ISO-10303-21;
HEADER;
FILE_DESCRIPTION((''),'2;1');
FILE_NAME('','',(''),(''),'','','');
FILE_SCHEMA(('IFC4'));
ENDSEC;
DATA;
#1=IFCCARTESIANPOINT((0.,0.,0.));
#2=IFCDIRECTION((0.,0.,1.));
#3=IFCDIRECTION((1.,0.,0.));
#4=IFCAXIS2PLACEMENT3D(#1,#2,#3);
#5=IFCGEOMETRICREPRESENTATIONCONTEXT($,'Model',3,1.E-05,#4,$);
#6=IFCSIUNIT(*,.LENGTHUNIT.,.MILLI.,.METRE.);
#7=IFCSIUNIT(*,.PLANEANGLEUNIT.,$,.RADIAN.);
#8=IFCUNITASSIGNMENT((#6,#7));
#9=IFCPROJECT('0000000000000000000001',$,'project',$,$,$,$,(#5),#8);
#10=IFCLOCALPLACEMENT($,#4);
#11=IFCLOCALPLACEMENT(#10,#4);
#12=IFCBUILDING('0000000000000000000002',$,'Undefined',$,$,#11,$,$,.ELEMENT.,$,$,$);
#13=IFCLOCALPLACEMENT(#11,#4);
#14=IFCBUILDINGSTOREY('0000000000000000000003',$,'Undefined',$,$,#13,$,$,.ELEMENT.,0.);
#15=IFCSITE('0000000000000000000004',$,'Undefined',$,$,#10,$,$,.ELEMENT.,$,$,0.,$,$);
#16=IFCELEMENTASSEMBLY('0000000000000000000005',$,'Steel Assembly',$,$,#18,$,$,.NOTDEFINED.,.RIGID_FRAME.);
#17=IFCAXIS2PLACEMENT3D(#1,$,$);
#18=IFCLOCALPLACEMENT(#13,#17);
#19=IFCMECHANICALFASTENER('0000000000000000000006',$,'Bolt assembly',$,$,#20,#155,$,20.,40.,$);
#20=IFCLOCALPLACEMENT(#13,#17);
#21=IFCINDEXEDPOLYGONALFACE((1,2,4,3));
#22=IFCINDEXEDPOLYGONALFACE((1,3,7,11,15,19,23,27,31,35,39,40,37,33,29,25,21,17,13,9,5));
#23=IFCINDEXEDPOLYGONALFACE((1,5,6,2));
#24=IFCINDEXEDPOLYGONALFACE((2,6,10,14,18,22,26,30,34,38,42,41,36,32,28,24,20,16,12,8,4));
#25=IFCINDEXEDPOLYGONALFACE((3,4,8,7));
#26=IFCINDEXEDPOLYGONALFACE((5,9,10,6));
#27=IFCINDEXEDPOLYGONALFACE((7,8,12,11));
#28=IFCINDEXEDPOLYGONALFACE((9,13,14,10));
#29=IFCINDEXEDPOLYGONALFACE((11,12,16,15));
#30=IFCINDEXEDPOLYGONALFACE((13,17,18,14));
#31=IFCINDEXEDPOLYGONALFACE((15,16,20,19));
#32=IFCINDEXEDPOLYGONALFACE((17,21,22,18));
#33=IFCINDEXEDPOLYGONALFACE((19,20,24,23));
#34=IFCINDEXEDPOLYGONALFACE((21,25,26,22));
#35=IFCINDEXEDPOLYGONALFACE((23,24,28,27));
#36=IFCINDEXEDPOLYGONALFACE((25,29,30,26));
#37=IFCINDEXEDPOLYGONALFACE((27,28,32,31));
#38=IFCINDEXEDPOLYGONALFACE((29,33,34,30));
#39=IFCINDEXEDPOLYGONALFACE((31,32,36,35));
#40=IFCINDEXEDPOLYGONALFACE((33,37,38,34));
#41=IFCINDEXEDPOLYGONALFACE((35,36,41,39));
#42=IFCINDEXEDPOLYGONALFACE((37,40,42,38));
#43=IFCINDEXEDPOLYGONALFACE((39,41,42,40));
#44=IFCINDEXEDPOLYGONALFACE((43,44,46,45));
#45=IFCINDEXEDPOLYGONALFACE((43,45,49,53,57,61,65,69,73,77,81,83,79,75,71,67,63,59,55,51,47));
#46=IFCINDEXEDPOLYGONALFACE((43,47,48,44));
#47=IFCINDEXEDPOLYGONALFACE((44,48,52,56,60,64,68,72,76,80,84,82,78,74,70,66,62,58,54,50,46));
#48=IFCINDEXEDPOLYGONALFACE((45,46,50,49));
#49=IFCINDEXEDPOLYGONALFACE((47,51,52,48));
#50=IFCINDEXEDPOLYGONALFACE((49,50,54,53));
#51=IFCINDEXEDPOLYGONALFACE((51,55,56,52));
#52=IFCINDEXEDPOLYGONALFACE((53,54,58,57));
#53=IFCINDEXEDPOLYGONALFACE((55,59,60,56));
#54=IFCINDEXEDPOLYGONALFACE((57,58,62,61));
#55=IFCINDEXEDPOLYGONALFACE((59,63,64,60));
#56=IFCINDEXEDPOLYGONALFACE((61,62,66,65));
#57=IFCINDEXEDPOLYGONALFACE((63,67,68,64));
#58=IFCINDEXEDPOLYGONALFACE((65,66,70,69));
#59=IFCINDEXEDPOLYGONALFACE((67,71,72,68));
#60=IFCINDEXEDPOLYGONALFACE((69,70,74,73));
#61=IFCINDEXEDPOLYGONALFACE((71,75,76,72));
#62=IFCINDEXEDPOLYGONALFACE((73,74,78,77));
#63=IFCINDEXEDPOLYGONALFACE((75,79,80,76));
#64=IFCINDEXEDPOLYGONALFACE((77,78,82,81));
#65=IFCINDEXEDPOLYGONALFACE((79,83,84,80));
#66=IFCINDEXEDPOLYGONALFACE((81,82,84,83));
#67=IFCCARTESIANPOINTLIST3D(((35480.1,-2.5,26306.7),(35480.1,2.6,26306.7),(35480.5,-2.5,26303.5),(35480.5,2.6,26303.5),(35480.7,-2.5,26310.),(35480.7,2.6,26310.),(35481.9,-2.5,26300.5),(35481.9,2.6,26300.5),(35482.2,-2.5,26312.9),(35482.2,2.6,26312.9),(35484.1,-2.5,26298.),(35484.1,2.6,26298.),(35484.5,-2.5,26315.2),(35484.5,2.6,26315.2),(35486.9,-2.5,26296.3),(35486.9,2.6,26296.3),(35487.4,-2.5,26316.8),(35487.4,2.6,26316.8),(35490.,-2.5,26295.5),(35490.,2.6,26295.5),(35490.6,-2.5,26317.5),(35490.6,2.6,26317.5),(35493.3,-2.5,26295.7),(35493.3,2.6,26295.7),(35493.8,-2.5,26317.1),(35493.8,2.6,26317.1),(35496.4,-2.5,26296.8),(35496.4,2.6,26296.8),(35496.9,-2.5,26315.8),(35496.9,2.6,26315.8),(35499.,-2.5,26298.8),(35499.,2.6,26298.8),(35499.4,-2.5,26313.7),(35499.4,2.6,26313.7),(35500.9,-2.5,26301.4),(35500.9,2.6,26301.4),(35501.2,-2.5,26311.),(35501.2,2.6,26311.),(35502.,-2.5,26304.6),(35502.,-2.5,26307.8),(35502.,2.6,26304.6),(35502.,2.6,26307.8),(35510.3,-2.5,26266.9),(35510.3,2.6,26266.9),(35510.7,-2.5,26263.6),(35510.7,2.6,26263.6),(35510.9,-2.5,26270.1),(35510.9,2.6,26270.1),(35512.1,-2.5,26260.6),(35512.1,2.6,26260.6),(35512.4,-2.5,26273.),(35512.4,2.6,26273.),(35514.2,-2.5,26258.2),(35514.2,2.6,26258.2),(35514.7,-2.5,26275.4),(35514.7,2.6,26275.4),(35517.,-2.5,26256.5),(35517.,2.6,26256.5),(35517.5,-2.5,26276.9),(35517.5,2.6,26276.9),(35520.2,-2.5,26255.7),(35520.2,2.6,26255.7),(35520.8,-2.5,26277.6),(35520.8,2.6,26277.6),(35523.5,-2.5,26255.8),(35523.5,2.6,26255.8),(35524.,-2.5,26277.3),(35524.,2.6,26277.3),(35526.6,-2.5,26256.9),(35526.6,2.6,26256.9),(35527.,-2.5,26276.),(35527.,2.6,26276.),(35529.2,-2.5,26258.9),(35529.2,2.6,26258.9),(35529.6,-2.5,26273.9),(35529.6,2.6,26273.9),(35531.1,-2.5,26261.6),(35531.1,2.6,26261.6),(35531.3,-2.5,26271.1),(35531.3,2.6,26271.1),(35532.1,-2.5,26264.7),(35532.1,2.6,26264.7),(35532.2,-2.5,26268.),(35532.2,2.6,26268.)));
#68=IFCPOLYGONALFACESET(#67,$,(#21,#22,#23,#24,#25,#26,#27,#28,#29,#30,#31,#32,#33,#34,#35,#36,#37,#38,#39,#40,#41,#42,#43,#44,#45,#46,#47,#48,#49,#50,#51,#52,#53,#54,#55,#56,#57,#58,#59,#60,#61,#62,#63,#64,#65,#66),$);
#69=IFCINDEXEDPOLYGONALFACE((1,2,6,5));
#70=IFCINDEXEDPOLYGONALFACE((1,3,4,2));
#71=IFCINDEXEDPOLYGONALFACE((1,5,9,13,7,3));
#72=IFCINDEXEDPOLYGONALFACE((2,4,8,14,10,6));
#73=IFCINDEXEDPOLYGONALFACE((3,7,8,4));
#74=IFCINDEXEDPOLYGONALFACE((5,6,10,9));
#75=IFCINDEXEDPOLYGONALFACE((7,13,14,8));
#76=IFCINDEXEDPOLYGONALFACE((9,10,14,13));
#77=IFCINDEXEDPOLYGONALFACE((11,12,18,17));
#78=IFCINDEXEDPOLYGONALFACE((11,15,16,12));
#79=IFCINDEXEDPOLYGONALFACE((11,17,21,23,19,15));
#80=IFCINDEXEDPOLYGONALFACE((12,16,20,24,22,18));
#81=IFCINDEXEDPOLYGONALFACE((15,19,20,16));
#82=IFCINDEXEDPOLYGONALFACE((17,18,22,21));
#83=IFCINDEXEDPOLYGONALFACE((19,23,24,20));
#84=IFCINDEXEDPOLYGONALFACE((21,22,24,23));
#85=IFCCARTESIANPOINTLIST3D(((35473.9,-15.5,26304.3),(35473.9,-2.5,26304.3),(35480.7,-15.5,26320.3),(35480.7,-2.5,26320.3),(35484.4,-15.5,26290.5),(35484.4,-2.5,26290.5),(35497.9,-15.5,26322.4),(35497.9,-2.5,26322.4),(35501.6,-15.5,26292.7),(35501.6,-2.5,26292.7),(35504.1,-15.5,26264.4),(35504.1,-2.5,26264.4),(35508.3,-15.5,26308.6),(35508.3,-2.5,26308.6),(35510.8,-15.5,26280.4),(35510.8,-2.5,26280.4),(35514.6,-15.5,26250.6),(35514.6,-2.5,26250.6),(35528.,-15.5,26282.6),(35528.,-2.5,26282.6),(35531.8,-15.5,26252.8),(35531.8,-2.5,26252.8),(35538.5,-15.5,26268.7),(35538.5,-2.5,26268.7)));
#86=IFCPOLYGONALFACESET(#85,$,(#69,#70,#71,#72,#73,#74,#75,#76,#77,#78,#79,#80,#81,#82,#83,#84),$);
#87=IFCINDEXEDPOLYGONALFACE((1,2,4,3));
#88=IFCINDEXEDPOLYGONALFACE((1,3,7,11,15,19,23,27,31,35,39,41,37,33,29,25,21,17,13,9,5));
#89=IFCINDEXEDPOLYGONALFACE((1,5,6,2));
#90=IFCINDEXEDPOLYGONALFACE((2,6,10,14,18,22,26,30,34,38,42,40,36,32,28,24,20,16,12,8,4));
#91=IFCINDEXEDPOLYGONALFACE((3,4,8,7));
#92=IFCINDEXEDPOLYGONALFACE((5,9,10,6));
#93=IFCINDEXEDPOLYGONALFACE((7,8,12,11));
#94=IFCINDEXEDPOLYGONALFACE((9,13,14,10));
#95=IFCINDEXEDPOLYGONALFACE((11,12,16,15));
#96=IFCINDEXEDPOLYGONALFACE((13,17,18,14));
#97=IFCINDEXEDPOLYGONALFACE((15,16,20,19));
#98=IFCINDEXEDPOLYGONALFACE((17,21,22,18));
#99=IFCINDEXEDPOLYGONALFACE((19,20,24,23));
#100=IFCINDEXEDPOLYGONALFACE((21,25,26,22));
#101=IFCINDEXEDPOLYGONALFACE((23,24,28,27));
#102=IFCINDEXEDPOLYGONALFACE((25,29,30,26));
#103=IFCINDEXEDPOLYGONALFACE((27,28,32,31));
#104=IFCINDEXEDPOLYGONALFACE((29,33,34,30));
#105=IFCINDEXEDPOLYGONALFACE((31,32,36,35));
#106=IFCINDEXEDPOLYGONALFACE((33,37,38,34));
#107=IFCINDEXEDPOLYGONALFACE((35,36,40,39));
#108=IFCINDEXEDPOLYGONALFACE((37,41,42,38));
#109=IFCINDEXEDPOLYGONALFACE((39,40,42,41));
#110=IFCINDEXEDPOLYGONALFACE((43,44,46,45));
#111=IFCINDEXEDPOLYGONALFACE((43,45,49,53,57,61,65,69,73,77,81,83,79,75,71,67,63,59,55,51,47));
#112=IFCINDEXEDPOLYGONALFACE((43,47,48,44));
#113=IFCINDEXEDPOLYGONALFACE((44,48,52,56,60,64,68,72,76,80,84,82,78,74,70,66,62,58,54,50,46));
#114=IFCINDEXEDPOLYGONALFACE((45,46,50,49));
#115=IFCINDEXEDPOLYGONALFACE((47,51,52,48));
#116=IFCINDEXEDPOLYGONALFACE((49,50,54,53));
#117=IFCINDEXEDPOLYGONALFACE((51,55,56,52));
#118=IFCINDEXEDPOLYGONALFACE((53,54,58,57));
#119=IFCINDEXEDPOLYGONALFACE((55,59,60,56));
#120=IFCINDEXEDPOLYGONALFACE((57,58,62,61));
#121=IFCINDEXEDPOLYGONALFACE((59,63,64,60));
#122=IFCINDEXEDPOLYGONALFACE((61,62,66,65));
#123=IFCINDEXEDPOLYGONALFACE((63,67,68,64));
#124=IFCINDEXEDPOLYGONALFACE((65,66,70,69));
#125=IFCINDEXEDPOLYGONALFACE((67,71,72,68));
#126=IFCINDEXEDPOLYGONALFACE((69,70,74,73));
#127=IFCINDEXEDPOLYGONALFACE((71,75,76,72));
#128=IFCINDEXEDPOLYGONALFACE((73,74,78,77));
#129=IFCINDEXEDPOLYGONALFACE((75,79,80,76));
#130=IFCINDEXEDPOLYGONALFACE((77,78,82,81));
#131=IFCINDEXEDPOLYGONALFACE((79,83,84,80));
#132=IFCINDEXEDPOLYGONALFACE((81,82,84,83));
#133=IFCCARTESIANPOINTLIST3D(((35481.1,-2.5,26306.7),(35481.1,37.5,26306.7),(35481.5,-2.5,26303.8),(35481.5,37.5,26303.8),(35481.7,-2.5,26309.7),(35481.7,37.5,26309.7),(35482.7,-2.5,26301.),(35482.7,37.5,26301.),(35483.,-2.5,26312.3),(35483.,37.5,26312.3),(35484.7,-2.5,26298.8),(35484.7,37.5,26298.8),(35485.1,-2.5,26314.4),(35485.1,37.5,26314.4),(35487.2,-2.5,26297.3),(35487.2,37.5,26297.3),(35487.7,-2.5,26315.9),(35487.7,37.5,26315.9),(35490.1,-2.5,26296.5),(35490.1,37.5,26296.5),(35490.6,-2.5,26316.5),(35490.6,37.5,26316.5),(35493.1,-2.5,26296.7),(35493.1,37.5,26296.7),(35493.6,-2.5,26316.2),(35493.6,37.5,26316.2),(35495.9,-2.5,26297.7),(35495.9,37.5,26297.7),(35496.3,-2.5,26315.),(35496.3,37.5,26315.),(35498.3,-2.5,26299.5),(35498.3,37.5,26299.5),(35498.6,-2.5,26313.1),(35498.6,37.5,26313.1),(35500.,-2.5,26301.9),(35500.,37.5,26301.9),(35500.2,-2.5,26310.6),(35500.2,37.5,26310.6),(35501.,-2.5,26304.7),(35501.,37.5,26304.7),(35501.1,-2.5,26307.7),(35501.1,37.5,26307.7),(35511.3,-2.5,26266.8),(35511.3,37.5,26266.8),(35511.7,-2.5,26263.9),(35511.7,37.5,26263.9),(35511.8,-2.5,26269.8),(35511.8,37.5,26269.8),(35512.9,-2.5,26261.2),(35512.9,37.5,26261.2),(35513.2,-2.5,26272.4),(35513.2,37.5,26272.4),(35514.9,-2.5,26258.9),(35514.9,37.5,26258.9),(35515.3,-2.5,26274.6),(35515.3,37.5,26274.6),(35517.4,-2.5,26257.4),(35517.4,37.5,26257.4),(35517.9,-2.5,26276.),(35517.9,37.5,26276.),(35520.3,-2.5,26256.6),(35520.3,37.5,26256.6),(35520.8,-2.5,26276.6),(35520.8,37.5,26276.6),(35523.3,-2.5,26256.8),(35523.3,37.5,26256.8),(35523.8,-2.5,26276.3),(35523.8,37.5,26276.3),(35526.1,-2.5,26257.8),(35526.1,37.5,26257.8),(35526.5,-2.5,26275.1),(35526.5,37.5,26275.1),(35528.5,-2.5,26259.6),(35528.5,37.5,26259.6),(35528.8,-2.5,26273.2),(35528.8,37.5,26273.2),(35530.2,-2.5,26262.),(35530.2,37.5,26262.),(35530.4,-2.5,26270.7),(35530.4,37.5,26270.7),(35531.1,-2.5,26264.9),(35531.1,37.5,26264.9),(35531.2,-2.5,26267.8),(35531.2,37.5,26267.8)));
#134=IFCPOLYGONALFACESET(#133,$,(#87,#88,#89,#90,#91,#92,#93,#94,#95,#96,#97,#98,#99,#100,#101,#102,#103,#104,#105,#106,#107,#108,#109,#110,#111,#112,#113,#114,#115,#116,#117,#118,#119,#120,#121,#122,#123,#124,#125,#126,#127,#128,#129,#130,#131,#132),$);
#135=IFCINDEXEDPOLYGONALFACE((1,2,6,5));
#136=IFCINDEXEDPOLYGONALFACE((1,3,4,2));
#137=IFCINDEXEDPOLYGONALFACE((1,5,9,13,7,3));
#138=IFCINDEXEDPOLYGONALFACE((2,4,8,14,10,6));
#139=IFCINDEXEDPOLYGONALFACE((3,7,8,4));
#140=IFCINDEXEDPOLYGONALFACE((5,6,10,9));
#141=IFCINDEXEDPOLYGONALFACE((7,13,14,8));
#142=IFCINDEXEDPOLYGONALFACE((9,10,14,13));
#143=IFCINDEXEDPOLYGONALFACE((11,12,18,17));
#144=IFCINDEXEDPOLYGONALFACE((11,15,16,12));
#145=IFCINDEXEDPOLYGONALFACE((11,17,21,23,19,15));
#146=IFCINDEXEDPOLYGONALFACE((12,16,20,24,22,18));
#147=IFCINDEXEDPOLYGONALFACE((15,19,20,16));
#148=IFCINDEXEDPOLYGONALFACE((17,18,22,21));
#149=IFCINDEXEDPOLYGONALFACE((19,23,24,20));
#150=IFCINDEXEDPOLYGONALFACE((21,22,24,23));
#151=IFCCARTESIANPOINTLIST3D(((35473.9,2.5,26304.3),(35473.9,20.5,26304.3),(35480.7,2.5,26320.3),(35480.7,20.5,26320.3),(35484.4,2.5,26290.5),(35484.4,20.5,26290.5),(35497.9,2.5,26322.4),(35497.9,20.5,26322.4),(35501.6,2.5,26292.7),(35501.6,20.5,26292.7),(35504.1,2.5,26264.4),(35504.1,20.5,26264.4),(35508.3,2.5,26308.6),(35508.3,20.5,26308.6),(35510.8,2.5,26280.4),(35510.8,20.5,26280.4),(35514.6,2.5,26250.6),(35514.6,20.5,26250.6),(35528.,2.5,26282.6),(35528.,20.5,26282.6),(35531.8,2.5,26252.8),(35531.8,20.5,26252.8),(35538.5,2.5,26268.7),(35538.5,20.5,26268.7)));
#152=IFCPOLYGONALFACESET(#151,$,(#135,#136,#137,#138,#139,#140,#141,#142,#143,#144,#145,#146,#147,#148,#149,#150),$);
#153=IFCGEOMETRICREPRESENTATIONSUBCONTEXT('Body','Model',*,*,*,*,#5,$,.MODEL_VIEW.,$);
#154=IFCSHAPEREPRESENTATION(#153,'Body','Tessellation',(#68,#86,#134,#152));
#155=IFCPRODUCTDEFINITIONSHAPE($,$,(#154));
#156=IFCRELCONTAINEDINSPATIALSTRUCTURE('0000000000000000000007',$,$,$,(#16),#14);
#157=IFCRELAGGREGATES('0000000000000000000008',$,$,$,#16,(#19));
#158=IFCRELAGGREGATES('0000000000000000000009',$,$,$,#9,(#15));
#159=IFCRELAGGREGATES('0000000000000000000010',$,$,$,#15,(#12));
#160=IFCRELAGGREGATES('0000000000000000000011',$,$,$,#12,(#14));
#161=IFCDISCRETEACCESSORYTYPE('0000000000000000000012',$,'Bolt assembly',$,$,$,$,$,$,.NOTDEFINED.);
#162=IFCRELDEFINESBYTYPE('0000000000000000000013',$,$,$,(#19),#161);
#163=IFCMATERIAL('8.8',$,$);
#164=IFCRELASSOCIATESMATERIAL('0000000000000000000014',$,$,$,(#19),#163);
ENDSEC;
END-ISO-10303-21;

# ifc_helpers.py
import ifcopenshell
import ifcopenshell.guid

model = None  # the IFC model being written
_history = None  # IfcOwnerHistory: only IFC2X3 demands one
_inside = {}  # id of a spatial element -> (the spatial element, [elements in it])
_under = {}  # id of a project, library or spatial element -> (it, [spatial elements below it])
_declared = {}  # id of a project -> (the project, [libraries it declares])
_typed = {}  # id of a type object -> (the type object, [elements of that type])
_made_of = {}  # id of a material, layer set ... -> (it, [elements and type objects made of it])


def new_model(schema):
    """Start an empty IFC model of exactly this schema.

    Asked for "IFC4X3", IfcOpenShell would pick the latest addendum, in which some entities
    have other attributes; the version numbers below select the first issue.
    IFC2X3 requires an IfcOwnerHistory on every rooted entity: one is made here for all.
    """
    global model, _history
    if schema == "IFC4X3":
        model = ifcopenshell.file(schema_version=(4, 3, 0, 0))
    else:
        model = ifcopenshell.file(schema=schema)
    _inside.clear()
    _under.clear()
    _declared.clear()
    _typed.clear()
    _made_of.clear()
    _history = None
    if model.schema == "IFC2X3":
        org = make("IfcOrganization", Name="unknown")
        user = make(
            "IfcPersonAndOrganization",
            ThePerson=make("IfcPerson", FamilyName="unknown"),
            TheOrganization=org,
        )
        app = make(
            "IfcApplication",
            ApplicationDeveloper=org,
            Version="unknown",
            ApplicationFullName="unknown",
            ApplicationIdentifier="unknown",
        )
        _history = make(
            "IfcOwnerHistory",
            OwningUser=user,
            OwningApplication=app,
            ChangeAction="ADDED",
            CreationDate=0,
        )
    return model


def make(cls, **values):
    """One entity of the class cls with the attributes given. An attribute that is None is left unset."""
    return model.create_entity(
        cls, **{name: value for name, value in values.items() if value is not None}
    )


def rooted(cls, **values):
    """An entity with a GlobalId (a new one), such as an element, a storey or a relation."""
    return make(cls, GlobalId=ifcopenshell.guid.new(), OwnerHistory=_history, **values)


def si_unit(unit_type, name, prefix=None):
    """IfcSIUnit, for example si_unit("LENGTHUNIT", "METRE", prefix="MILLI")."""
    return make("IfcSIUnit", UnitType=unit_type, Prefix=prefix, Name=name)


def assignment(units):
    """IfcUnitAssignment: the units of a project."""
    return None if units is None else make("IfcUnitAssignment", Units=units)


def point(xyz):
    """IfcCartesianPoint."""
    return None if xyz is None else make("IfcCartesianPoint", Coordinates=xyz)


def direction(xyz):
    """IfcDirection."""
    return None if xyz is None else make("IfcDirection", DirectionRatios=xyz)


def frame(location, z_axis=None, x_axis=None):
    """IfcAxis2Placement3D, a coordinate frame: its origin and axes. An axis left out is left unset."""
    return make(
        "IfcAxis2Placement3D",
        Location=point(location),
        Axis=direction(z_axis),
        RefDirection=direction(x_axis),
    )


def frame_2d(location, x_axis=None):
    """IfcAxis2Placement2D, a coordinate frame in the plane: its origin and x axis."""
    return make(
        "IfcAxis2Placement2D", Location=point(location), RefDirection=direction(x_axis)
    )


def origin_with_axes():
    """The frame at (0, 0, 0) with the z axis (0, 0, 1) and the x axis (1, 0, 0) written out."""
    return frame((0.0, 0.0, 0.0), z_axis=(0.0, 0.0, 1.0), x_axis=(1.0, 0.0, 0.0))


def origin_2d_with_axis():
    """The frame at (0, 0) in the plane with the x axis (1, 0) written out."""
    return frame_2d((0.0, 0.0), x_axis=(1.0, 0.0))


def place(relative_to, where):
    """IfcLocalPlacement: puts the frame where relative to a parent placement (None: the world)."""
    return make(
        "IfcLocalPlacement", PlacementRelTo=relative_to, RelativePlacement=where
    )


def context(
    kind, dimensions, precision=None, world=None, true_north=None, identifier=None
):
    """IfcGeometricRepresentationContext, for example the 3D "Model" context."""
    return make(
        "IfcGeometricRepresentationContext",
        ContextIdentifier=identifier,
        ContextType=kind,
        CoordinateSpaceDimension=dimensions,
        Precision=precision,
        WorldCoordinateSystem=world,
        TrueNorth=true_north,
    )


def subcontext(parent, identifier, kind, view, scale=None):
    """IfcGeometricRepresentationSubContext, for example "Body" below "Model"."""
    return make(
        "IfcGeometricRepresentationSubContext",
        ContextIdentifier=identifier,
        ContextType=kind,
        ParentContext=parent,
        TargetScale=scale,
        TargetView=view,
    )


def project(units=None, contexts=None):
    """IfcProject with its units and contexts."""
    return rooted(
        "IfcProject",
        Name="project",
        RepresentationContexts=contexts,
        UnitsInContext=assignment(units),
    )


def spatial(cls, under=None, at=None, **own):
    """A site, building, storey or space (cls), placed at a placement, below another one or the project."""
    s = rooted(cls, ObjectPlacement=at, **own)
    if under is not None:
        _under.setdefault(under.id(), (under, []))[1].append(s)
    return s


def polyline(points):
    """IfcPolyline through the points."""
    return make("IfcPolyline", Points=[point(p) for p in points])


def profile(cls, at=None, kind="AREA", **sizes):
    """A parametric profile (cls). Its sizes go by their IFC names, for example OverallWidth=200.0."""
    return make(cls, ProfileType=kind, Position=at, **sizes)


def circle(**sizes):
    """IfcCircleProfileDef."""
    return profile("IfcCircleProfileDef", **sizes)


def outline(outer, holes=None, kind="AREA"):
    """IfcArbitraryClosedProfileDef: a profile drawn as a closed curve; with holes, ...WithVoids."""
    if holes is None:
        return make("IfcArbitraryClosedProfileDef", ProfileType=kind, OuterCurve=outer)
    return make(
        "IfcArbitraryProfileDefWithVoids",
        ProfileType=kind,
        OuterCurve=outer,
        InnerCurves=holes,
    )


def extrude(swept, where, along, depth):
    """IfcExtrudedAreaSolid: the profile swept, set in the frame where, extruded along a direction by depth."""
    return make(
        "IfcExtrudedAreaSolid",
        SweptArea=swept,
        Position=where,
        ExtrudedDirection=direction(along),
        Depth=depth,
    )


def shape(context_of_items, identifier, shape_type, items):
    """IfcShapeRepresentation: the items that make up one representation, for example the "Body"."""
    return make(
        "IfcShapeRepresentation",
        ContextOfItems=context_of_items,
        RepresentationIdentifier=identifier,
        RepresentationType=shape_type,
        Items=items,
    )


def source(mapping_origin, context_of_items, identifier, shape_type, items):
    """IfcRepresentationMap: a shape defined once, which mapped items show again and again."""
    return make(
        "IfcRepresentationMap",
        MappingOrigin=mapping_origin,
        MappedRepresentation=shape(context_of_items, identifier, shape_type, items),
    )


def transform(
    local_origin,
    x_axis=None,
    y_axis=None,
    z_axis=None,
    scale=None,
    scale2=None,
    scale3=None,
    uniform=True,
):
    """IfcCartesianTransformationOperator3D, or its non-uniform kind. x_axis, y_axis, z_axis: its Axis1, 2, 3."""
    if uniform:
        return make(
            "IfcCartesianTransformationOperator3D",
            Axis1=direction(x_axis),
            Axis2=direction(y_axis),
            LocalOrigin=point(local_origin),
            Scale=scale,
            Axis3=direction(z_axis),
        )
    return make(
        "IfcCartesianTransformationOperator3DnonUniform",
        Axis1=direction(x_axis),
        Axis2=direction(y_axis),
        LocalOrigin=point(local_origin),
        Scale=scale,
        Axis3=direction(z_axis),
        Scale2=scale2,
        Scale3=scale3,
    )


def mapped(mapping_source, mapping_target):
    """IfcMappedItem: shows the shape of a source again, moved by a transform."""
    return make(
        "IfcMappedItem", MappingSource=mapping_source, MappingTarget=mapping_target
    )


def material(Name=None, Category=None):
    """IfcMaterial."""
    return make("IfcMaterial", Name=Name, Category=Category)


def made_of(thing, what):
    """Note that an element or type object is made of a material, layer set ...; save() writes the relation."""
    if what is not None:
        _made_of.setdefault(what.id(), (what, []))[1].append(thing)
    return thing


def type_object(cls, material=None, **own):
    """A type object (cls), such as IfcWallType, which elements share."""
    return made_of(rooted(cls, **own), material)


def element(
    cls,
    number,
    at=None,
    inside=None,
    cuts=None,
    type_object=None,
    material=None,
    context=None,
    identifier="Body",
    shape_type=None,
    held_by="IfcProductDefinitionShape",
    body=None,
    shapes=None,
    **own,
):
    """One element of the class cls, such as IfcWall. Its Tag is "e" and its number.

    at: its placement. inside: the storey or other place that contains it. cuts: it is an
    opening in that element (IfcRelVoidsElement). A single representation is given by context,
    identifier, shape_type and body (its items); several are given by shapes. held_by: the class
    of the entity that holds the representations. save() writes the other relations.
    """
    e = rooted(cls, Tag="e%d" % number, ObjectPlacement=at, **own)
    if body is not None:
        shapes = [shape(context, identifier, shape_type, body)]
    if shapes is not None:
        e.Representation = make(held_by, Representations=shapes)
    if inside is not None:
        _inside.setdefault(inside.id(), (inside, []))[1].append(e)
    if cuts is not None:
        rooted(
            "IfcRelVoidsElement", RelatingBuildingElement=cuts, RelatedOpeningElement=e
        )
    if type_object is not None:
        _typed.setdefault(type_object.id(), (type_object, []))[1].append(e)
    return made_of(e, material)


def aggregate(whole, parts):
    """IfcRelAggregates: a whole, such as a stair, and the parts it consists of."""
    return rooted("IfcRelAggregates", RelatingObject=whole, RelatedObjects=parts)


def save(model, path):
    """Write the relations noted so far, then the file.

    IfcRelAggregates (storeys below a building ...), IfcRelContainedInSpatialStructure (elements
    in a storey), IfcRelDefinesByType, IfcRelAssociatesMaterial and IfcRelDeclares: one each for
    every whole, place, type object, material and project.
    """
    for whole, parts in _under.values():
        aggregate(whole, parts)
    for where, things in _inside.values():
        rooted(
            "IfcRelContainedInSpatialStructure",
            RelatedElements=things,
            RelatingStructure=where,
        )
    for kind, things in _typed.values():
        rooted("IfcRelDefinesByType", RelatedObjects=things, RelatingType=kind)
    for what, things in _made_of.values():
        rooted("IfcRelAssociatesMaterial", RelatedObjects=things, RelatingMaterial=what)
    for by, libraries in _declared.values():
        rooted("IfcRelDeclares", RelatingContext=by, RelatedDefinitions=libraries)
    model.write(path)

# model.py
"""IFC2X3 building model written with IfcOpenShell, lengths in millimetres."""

from ifc_helpers import new_model, si_unit, frame, origin_with_axes, origin_2d_with_axis, place, context, subcontext, project, spatial, polyline, circle, outline, extrude, source, transform, mapped, material, type_object, element, aggregate, save


model = new_model("IFC2X3")

# Units and contexts
model_context = context("Model", 3, precision=1e-05, world=origin_with_axes())
body_context = subcontext(model_context, "Body", "Model", "MODEL_VIEW")
ifc_project = project(units=[si_unit("LENGTHUNIT", "METRE", prefix="MILLI"), si_unit("PLANEANGLEUNIT", "RADIAN")], contexts=[model_context])

# Site, building, storey
site_placement = place(None, origin_with_axes())
site = spatial("IfcSite", under=ifc_project, at=site_placement, Name="Undefined", CompositionType="ELEMENT", RefElevation=0.0)
building_placement = place(site_placement, origin_with_axes())
building = spatial("IfcBuilding", under=site, at=building_placement, Name="Undefined", CompositionType="ELEMENT")
storey_placement = place(building_placement, origin_with_axes())
storey = spatial("IfcBuildingStorey", under=building, at=storey_placement, Name="Undefined", CompositionType="ELEMENT", Elevation=0.0)

# Element assembly
assembly_1_placement = place(storey_placement, origin_with_axes())
assembly_1 = element("IfcElementAssembly", 1, at=assembly_1_placement, inside=storey, Name="Steel Assembly", AssemblyPlace="NOTDEFINED", PredefinedType="RIGID_FRAME")

# Shared definitions
discrete_accessory_type_1 = type_object("IfcDiscreteAccessoryType", Name="Bolt assembly")
ifc_material_1 = material(Name="8.8")

# Mechanical fastener
shared_shape_1 = source(origin_with_axes(), body_context, "Body", "SweptSolid", [
    extrude(circle(Radius=11.0, at=origin_2d_with_axis()), frame((0.0, -2.5, 0.0), z_axis=(0.0, 1.0, 0.0), x_axis=(1.0, 0.0, 0.0)), (0.0, 0.0, 1.0), 5.1),
    extrude(outline(polyline([(17.3, 0.0), (8.7, 15.0), (-8.7, 15.0), (-17.3, 0.0), (-8.7, -15.0), (8.7, -15.0), (17.3, 0.0)])), frame((0.0, -15.5, 0.0), z_axis=(0.0, 1.0, 0.0), x_axis=(1.0, 0.0, 0.0)), (0.0, 0.0, 1.0), 13.0),
    extrude(circle(Radius=10.0, at=origin_2d_with_axis()), frame((0.0, -2.5, 0.0), z_axis=(0.0, 1.0, 0.0), x_axis=(1.0, 0.0, 0.0)), (0.0, 0.0, 1.0), 40.0),
    extrude(outline(polyline([(17.3, 0.0), (8.7, 15.0), (-8.7, 15.0), (-17.3, 0.0), (-8.7, -15.0), (8.7, -15.0), (17.3, 0.0)])), frame((0.0, 2.5, 0.0), z_axis=(0.0, 1.0, 0.0), x_axis=(1.0, 0.0, 0.0)), (0.0, 0.0, 1.0), 18.0),
])
mechanical_fastener_1_placement = place(assembly_1_placement, frame((35521.3, 0.0, 26266.6), z_axis=(-0.797403, 0.0, -0.603447), x_axis=(-0.603447, 0.0, 0.797403)))
mechanical_fastener_1 = element("IfcMechanicalFastener", 2, at=mechanical_fastener_1_placement, type_object=discrete_accessory_type_1, material=ifc_material_1, Name="Bolt assembly", NominalDiameter=20.0, NominalLength=40.0, context=body_context, shape_type="MappedRepresentation", body=[
    mapped(shared_shape_1, transform((0.0, 0.0, 0.0))),
    mapped(shared_shape_1, transform((50.0, 0.0, 0.0))),
])
aggregate(assembly_1, [mechanical_fastener_1])

save(model, "model.ifc")
